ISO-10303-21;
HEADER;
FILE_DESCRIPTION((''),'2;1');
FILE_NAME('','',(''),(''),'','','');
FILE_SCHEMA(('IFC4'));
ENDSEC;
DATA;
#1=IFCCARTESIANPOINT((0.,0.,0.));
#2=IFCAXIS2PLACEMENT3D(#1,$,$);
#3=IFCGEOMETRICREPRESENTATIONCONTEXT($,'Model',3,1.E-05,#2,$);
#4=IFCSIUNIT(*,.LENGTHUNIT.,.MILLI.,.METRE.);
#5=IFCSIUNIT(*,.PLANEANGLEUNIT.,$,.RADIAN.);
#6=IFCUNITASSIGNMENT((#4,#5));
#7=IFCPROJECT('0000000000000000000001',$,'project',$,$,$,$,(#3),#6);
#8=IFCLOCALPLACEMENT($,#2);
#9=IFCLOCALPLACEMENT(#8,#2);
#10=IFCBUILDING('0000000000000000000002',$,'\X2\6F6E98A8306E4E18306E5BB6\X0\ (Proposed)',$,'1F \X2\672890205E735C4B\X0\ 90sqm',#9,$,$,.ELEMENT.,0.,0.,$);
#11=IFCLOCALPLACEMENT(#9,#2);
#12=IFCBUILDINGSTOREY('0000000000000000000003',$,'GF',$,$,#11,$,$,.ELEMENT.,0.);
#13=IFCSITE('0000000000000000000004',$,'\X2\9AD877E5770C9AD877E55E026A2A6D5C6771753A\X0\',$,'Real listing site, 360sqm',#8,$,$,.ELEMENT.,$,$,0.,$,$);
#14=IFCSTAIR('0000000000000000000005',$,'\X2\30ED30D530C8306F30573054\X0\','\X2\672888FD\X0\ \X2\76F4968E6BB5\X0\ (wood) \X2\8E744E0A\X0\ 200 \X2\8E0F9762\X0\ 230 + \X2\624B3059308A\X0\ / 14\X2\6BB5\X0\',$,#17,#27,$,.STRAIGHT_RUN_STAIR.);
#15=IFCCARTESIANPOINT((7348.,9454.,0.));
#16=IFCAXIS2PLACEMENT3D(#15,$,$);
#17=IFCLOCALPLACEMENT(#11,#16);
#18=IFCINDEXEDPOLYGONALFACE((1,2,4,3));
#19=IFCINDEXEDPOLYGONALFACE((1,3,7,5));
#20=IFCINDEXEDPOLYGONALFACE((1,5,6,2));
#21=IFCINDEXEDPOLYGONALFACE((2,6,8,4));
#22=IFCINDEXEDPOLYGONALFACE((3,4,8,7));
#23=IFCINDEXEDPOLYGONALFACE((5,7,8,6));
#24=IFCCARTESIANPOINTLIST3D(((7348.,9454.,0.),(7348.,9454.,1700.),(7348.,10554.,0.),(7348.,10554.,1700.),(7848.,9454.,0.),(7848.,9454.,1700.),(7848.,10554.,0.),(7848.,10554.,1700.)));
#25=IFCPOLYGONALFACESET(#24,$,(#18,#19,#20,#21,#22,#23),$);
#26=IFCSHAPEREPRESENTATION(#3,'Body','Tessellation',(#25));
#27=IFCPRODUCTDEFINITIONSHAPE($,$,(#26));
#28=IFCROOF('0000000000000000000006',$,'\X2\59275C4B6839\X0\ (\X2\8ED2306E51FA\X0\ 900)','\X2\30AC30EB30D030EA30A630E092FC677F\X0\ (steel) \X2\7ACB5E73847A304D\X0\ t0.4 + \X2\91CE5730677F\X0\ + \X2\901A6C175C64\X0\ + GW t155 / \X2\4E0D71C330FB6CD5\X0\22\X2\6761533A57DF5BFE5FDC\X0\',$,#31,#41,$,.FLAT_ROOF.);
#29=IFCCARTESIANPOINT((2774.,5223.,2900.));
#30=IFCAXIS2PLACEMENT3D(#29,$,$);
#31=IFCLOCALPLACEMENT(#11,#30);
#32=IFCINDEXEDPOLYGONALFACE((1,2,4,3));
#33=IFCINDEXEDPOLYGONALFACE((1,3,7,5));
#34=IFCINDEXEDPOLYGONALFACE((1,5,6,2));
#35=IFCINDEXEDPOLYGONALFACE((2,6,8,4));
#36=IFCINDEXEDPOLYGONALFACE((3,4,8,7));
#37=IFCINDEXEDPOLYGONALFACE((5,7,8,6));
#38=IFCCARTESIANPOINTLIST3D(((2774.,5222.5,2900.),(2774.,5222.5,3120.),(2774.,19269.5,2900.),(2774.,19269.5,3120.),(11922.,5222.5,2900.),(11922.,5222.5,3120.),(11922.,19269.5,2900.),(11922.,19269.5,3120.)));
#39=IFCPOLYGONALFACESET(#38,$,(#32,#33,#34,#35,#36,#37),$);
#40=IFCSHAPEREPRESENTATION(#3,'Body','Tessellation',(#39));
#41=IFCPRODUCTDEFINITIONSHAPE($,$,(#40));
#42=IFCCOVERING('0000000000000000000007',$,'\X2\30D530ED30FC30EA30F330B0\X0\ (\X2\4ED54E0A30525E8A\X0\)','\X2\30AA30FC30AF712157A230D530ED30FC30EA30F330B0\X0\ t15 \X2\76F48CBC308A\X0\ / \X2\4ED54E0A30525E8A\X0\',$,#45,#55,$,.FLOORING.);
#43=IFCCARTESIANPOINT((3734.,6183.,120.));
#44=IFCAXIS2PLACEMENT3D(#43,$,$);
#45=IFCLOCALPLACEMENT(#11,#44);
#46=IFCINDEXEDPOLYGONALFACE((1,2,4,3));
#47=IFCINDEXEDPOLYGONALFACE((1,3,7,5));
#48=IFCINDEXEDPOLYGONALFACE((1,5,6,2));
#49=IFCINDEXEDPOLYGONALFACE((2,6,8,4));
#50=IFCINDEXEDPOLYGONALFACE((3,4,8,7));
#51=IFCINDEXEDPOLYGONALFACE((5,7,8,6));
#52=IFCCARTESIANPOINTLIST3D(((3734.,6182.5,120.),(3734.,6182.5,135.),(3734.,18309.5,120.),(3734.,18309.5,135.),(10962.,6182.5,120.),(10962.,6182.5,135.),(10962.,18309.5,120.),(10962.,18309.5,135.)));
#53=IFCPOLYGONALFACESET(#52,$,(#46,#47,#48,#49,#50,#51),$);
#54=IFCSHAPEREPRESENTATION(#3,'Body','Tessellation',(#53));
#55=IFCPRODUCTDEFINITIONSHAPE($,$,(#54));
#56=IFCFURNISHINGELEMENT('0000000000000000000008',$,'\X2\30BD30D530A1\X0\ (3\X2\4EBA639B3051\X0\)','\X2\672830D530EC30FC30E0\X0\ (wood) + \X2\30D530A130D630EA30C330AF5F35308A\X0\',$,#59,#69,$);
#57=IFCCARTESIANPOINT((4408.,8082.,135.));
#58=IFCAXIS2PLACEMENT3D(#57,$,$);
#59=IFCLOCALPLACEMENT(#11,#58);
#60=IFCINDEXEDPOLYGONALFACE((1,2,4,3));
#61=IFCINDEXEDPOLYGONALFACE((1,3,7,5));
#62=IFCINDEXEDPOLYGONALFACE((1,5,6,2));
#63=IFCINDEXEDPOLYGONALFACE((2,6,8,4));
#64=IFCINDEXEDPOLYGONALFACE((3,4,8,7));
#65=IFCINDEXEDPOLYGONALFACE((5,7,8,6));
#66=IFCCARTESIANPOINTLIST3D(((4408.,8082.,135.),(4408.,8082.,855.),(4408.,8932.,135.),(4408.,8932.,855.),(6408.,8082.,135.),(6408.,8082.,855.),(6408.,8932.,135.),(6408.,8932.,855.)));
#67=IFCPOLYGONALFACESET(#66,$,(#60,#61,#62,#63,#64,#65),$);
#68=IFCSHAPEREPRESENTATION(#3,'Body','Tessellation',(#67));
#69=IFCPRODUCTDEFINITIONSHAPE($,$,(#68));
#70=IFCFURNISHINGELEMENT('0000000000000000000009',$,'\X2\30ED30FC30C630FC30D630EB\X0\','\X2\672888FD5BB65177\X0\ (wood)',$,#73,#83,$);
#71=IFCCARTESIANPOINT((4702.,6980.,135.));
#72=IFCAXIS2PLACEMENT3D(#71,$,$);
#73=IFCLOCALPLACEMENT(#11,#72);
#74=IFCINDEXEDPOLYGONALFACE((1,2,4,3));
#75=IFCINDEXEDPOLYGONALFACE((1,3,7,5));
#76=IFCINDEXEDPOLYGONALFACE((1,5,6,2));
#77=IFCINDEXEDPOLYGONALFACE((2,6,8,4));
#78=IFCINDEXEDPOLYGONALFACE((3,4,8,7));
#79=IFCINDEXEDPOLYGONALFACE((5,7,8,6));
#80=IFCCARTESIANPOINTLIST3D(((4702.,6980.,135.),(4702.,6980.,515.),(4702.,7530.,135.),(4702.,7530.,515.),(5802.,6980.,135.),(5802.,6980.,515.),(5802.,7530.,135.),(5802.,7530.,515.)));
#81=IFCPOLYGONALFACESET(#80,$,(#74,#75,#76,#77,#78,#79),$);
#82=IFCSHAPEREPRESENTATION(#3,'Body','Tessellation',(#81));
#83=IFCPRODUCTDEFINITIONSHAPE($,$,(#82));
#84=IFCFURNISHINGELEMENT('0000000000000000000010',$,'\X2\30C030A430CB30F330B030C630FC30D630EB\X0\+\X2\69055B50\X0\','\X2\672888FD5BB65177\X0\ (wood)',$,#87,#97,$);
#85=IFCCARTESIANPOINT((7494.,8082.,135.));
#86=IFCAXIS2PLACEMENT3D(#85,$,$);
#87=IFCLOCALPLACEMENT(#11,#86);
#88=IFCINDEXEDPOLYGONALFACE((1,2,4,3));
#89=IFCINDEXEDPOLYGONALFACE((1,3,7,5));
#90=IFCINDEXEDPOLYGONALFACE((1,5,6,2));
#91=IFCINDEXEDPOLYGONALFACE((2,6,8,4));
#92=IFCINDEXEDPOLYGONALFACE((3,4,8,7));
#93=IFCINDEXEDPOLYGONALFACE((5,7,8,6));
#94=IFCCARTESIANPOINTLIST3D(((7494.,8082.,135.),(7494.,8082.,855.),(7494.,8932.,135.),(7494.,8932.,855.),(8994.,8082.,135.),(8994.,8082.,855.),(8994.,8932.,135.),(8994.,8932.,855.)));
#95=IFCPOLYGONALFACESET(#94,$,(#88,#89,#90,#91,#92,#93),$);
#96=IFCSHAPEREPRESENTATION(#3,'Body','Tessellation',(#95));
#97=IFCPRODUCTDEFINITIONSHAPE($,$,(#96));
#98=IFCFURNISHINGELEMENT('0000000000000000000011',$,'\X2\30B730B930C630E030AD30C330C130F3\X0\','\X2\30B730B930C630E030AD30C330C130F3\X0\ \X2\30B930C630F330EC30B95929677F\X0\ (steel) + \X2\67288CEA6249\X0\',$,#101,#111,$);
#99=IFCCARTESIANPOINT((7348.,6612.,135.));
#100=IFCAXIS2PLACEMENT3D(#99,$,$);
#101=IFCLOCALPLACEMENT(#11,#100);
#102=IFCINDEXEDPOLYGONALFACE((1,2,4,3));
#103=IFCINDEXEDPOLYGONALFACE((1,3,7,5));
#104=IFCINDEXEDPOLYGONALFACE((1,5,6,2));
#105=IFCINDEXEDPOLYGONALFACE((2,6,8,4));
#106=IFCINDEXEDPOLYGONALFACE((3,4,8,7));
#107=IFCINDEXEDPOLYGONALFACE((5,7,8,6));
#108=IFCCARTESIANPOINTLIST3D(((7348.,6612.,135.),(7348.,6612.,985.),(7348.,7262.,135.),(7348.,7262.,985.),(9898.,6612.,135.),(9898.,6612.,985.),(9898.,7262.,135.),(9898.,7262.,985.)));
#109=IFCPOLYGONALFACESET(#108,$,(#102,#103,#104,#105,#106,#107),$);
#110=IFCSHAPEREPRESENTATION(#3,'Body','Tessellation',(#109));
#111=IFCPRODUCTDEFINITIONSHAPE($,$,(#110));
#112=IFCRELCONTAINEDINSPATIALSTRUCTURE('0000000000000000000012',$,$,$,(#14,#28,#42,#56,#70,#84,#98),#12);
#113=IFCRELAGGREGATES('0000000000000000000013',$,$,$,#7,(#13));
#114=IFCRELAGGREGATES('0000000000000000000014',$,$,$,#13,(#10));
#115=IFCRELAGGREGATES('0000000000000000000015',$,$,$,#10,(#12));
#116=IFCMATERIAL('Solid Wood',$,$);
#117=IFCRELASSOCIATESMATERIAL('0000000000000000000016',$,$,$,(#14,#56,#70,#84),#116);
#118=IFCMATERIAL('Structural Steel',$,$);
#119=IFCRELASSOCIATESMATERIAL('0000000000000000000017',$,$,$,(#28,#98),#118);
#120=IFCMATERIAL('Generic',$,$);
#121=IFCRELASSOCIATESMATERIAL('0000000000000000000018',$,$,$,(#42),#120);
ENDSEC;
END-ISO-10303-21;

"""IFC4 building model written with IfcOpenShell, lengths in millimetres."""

from ifc_helpers import new_model, si_unit, frame, frame_2d, origin, place, context, project, spatial, rectangle, extrude, material, element, save


model = new_model("IFC4")

# Units and contexts
model_context = context("Model", 3, precision=1e-05, world=origin())
ifc_project = project(units=[si_unit("LENGTHUNIT", "METRE", prefix="MILLI"), si_unit("PLANEANGLEUNIT", "RADIAN")], contexts=[model_context])

# Site, building, storey
site_placement = place(None, origin())
site = spatial("IfcSite", under=ifc_project, at=site_placement, Name="高知県高知市横浜東町", ObjectType="Real listing site, 360sqm", CompositionType="ELEMENT", RefElevation=0.0)
building_placement = place(site_placement, origin())
building = spatial("IfcBuilding", under=site, at=building_placement, Name="潮風の丘の家 (Proposed)", ObjectType="1F 木造平屋 90sqm", CompositionType="ELEMENT", ElevationOfRefHeight=0.0, ElevationOfTerrain=0.0)
storey_placement = place(building_placement, origin())
storey = spatial("IfcBuildingStorey", under=building, at=storey_placement, Name="GF", CompositionType="ELEMENT", Elevation=0.0)

# Shared definitions
ifc_material_1 = material(Name="Solid Wood")

# Stair
stair_placement = place(storey_placement, frame((7348.0, 9454.0, 0.0)))
element("IfcStair", 1, at=stair_placement, inside=storey, material=ifc_material_1, Name="ロフトはしご", Description="木製 直階段 (wood) 蹴上 200 踏面 230 + 手すり / 14段", PredefinedType="STRAIGHT_RUN_STAIR", context=model_context, shape_type="SweptSolid", body=[
    extrude(rectangle(XDim=500.0, YDim=1100.0, at=frame_2d((250.0, 550.0))), frame((7348.0, 9454.0, 0.0)), (0.0, 0.0, 1.0), 1700.0),
])

# Roof
ifc_material_2 = material(Name="Structural Steel")
roof_placement = place(storey_placement, frame((2774.0, 5223.0, 2900.0)))
element("IfcRoof", 2, at=roof_placement, inside=storey, material=ifc_material_2, Name="大屋根 (軒の出 900)", Description="ガルバリウム鋼板 (steel) 立平葺き t0.4 + 野地板 + 通気層 + GW t155 / 不燃・法22条区域対応", PredefinedType="FLAT_ROOF", context=model_context, shape_type="SweptSolid", body=[
    extrude(rectangle(XDim=9148.0, YDim=14047.0, at=frame_2d((4574.0, 7023.0))), frame((2774.0, 5223.0, 2900.0)), (0.0, 0.0, 1.0), 220.0),
])

# Covering
ifc_material_3 = material(Name="Generic")
covering_placement = place(storey_placement, frame((3734.0, 6183.0, 120.0)))
element("IfcCovering", 3, at=covering_placement, inside=storey, material=ifc_material_3, Name="フローリング (仕上げ床)", Description="オーク無垢フローリング t15 直貼り / 仕上げ床", PredefinedType="FLOORING", context=model_context, shape_type="SweptSolid", body=[
    extrude(rectangle(XDim=7228.0, YDim=12127.0, at=frame_2d((3614.0, 6063.0))), frame((3734.0, 6183.0, 120.0)), (0.0, 0.0, 1.0), 15.0),
])

# Furnishing elements
furnishing_1_placement = place(storey_placement, frame((4408.0, 8082.0, 135.0)))
element("IfcFurnishingElement", 4, at=furnishing_1_placement, inside=storey, material=ifc_material_1, Name="ソファ (3人掛け)", Description="木フレーム (wood) + ファブリック張り", context=model_context, shape_type="SweptSolid", body=[
    extrude(rectangle(XDim=2000.0, YDim=850.0, at=frame_2d((1000.0, 425.0))), frame((4408.0, 8082.0, 135.0)), (0.0, 0.0, 1.0), 720.0),
])
furnishing_2_placement = place(storey_placement, frame((4702.0, 6980.0, 135.0)))
element("IfcFurnishingElement", 5, at=furnishing_2_placement, inside=storey, material=ifc_material_1, Name="ローテーブル", Description="木製家具 (wood)", context=model_context, shape_type="SweptSolid", body=[
    extrude(rectangle(XDim=1100.0, YDim=550.0, at=frame_2d((550.0, 275.0))), frame((4702.0, 6980.0, 135.0)), (0.0, 0.0, 1.0), 380.0),
])
furnishing_3_placement = place(storey_placement, frame((7494.0, 8082.0, 135.0)))
element("IfcFurnishingElement", 6, at=furnishing_3_placement, inside=storey, material=ifc_material_1, Name="ダイニングテーブル+椅子", Description="木製家具 (wood)", context=model_context, shape_type="SweptSolid", body=[
    extrude(rectangle(XDim=1500.0, YDim=850.0, at=frame_2d((750.0, 425.0))), frame((7494.0, 8082.0, 135.0)), (0.0, 0.0, 1.0), 720.0),
])
furnishing_4_placement = place(storey_placement, frame((7348.0, 6612.0, 135.0)))
element("IfcFurnishingElement", 7, at=furnishing_4_placement, inside=storey, material=ifc_material_2, Name="システムキッチン", Description="システムキッチン ステンレス天板 (steel) + 木質扉", context=model_context, shape_type="SweptSolid", body=[
    extrude(rectangle(XDim=2550.0, YDim=650.0, at=frame_2d((1275.0, 325.0))), frame((7348.0, 6612.0, 135.0)), (0.0, 0.0, 1.0), 850.0),
])

save(model, "model.ifc")
